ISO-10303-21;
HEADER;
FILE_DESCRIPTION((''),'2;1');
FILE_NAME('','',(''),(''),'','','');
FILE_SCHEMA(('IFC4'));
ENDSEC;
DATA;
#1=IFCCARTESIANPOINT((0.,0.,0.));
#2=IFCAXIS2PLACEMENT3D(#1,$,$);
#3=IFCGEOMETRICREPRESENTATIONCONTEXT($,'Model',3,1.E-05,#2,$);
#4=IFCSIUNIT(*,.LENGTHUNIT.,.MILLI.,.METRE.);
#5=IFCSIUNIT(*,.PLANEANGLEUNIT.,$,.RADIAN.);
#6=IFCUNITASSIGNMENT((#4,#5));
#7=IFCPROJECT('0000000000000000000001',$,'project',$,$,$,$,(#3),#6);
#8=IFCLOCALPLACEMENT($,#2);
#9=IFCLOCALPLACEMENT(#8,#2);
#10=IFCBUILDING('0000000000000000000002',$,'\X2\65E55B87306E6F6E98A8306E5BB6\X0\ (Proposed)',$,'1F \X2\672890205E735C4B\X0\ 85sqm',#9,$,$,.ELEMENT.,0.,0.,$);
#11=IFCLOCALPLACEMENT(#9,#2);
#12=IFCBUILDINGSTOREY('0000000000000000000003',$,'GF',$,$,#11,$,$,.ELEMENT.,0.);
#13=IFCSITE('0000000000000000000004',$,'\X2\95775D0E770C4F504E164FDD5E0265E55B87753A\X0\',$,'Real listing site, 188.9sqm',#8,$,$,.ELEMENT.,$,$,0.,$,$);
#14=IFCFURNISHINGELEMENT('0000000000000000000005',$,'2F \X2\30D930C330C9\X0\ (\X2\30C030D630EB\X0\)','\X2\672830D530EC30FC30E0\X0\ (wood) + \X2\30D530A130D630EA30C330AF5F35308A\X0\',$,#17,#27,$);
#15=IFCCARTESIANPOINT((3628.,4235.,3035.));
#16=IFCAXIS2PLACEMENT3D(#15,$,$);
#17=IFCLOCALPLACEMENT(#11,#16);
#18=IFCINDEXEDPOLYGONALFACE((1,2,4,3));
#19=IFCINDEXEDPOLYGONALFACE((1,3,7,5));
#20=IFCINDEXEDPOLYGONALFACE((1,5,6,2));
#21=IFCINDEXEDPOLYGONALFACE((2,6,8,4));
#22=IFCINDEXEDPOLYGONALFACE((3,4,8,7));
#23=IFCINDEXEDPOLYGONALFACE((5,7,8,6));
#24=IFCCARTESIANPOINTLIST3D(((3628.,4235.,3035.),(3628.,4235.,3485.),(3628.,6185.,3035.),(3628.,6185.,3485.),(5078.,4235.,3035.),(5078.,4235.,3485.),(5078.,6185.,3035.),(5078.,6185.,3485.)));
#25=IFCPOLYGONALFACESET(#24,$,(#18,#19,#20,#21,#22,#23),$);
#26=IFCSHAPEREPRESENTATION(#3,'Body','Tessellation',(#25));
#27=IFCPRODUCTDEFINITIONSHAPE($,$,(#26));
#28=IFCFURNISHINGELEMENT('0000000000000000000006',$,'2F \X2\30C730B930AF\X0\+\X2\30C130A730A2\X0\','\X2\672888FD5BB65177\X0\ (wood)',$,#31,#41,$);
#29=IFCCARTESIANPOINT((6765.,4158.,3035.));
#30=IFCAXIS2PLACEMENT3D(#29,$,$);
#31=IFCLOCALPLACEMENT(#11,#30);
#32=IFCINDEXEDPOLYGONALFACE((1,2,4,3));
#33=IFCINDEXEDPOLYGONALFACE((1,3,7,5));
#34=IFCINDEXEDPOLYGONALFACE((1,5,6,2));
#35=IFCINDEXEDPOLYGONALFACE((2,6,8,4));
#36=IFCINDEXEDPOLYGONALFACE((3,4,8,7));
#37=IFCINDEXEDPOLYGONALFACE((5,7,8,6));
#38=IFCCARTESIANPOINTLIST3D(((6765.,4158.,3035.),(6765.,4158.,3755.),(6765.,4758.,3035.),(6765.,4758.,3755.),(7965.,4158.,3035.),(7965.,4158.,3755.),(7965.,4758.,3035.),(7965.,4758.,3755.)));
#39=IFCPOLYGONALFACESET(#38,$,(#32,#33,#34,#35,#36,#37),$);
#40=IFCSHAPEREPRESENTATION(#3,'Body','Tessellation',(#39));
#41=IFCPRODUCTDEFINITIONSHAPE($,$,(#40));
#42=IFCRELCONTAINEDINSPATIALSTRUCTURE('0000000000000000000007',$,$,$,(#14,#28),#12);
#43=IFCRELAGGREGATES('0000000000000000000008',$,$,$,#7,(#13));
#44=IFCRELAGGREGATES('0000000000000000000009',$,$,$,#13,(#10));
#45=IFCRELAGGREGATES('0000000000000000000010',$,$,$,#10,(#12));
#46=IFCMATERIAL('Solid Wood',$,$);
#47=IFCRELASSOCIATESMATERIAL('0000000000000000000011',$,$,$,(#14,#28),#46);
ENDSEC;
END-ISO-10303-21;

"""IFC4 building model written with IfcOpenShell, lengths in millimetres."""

from ifc_helpers import new_model, si_unit, frame, frame_2d, origin, place, context, project, spatial, rectangle, extrude, material, element, save


model = new_model("IFC4")

# Units and contexts
model_context = context("Model", 3, precision=1e-05, world=origin())
ifc_project = project(units=[si_unit("LENGTHUNIT", "METRE", prefix="MILLI"), si_unit("PLANEANGLEUNIT", "RADIAN")], contexts=[model_context])

# Site, building, storey
site_placement = place(None, origin())
site = spatial("IfcSite", under=ifc_project, at=site_placement, Name="長崎県佐世保市日宇町", ObjectType="Real listing site, 188.9sqm", CompositionType="ELEMENT", RefElevation=0.0)
building_placement = place(site_placement, origin())
building = spatial("IfcBuilding", under=site, at=building_placement, Name="日宇の潮風の家 (Proposed)", ObjectType="1F 木造平屋 85sqm", CompositionType="ELEMENT", ElevationOfRefHeight=0.0, ElevationOfTerrain=0.0)
storey_placement = place(building_placement, origin())
storey = spatial("IfcBuildingStorey", under=building, at=storey_placement, Name="GF", CompositionType="ELEMENT", Elevation=0.0)

# Shared definitions
ifc_material_1 = material(Name="Solid Wood")

# Furnishing elements
furnishing_1_placement = place(storey_placement, frame((3628.0, 4235.0, 3035.0)))
element("IfcFurnishingElement", 1, at=furnishing_1_placement, inside=storey, material=ifc_material_1, Name="2F ベッド (ダブル)", Description="木フレーム (wood) + ファブリック張り", context=model_context, shape_type="SweptSolid", body=[
    extrude(rectangle(XDim=1450.0, YDim=1950.0, at=frame_2d((725.0, 975.0))), frame((3628.0, 4235.0, 3035.0)), (0.0, 0.0, 1.0), 450.0),
])
furnishing_2_placement = place(storey_placement, frame((6765.0, 4158.0, 3035.0)))
element("IfcFurnishingElement", 2, at=furnishing_2_placement, inside=storey, material=ifc_material_1, Name="2F デスク+チェア", Description="木製家具 (wood)", context=model_context, shape_type="SweptSolid", body=[
    extrude(rectangle(XDim=1200.0, YDim=600.0, at=frame_2d((600.0, 300.0))), frame((6765.0, 4158.0, 3035.0)), (0.0, 0.0, 1.0), 720.0),
])

save(model, "model.ifc")
